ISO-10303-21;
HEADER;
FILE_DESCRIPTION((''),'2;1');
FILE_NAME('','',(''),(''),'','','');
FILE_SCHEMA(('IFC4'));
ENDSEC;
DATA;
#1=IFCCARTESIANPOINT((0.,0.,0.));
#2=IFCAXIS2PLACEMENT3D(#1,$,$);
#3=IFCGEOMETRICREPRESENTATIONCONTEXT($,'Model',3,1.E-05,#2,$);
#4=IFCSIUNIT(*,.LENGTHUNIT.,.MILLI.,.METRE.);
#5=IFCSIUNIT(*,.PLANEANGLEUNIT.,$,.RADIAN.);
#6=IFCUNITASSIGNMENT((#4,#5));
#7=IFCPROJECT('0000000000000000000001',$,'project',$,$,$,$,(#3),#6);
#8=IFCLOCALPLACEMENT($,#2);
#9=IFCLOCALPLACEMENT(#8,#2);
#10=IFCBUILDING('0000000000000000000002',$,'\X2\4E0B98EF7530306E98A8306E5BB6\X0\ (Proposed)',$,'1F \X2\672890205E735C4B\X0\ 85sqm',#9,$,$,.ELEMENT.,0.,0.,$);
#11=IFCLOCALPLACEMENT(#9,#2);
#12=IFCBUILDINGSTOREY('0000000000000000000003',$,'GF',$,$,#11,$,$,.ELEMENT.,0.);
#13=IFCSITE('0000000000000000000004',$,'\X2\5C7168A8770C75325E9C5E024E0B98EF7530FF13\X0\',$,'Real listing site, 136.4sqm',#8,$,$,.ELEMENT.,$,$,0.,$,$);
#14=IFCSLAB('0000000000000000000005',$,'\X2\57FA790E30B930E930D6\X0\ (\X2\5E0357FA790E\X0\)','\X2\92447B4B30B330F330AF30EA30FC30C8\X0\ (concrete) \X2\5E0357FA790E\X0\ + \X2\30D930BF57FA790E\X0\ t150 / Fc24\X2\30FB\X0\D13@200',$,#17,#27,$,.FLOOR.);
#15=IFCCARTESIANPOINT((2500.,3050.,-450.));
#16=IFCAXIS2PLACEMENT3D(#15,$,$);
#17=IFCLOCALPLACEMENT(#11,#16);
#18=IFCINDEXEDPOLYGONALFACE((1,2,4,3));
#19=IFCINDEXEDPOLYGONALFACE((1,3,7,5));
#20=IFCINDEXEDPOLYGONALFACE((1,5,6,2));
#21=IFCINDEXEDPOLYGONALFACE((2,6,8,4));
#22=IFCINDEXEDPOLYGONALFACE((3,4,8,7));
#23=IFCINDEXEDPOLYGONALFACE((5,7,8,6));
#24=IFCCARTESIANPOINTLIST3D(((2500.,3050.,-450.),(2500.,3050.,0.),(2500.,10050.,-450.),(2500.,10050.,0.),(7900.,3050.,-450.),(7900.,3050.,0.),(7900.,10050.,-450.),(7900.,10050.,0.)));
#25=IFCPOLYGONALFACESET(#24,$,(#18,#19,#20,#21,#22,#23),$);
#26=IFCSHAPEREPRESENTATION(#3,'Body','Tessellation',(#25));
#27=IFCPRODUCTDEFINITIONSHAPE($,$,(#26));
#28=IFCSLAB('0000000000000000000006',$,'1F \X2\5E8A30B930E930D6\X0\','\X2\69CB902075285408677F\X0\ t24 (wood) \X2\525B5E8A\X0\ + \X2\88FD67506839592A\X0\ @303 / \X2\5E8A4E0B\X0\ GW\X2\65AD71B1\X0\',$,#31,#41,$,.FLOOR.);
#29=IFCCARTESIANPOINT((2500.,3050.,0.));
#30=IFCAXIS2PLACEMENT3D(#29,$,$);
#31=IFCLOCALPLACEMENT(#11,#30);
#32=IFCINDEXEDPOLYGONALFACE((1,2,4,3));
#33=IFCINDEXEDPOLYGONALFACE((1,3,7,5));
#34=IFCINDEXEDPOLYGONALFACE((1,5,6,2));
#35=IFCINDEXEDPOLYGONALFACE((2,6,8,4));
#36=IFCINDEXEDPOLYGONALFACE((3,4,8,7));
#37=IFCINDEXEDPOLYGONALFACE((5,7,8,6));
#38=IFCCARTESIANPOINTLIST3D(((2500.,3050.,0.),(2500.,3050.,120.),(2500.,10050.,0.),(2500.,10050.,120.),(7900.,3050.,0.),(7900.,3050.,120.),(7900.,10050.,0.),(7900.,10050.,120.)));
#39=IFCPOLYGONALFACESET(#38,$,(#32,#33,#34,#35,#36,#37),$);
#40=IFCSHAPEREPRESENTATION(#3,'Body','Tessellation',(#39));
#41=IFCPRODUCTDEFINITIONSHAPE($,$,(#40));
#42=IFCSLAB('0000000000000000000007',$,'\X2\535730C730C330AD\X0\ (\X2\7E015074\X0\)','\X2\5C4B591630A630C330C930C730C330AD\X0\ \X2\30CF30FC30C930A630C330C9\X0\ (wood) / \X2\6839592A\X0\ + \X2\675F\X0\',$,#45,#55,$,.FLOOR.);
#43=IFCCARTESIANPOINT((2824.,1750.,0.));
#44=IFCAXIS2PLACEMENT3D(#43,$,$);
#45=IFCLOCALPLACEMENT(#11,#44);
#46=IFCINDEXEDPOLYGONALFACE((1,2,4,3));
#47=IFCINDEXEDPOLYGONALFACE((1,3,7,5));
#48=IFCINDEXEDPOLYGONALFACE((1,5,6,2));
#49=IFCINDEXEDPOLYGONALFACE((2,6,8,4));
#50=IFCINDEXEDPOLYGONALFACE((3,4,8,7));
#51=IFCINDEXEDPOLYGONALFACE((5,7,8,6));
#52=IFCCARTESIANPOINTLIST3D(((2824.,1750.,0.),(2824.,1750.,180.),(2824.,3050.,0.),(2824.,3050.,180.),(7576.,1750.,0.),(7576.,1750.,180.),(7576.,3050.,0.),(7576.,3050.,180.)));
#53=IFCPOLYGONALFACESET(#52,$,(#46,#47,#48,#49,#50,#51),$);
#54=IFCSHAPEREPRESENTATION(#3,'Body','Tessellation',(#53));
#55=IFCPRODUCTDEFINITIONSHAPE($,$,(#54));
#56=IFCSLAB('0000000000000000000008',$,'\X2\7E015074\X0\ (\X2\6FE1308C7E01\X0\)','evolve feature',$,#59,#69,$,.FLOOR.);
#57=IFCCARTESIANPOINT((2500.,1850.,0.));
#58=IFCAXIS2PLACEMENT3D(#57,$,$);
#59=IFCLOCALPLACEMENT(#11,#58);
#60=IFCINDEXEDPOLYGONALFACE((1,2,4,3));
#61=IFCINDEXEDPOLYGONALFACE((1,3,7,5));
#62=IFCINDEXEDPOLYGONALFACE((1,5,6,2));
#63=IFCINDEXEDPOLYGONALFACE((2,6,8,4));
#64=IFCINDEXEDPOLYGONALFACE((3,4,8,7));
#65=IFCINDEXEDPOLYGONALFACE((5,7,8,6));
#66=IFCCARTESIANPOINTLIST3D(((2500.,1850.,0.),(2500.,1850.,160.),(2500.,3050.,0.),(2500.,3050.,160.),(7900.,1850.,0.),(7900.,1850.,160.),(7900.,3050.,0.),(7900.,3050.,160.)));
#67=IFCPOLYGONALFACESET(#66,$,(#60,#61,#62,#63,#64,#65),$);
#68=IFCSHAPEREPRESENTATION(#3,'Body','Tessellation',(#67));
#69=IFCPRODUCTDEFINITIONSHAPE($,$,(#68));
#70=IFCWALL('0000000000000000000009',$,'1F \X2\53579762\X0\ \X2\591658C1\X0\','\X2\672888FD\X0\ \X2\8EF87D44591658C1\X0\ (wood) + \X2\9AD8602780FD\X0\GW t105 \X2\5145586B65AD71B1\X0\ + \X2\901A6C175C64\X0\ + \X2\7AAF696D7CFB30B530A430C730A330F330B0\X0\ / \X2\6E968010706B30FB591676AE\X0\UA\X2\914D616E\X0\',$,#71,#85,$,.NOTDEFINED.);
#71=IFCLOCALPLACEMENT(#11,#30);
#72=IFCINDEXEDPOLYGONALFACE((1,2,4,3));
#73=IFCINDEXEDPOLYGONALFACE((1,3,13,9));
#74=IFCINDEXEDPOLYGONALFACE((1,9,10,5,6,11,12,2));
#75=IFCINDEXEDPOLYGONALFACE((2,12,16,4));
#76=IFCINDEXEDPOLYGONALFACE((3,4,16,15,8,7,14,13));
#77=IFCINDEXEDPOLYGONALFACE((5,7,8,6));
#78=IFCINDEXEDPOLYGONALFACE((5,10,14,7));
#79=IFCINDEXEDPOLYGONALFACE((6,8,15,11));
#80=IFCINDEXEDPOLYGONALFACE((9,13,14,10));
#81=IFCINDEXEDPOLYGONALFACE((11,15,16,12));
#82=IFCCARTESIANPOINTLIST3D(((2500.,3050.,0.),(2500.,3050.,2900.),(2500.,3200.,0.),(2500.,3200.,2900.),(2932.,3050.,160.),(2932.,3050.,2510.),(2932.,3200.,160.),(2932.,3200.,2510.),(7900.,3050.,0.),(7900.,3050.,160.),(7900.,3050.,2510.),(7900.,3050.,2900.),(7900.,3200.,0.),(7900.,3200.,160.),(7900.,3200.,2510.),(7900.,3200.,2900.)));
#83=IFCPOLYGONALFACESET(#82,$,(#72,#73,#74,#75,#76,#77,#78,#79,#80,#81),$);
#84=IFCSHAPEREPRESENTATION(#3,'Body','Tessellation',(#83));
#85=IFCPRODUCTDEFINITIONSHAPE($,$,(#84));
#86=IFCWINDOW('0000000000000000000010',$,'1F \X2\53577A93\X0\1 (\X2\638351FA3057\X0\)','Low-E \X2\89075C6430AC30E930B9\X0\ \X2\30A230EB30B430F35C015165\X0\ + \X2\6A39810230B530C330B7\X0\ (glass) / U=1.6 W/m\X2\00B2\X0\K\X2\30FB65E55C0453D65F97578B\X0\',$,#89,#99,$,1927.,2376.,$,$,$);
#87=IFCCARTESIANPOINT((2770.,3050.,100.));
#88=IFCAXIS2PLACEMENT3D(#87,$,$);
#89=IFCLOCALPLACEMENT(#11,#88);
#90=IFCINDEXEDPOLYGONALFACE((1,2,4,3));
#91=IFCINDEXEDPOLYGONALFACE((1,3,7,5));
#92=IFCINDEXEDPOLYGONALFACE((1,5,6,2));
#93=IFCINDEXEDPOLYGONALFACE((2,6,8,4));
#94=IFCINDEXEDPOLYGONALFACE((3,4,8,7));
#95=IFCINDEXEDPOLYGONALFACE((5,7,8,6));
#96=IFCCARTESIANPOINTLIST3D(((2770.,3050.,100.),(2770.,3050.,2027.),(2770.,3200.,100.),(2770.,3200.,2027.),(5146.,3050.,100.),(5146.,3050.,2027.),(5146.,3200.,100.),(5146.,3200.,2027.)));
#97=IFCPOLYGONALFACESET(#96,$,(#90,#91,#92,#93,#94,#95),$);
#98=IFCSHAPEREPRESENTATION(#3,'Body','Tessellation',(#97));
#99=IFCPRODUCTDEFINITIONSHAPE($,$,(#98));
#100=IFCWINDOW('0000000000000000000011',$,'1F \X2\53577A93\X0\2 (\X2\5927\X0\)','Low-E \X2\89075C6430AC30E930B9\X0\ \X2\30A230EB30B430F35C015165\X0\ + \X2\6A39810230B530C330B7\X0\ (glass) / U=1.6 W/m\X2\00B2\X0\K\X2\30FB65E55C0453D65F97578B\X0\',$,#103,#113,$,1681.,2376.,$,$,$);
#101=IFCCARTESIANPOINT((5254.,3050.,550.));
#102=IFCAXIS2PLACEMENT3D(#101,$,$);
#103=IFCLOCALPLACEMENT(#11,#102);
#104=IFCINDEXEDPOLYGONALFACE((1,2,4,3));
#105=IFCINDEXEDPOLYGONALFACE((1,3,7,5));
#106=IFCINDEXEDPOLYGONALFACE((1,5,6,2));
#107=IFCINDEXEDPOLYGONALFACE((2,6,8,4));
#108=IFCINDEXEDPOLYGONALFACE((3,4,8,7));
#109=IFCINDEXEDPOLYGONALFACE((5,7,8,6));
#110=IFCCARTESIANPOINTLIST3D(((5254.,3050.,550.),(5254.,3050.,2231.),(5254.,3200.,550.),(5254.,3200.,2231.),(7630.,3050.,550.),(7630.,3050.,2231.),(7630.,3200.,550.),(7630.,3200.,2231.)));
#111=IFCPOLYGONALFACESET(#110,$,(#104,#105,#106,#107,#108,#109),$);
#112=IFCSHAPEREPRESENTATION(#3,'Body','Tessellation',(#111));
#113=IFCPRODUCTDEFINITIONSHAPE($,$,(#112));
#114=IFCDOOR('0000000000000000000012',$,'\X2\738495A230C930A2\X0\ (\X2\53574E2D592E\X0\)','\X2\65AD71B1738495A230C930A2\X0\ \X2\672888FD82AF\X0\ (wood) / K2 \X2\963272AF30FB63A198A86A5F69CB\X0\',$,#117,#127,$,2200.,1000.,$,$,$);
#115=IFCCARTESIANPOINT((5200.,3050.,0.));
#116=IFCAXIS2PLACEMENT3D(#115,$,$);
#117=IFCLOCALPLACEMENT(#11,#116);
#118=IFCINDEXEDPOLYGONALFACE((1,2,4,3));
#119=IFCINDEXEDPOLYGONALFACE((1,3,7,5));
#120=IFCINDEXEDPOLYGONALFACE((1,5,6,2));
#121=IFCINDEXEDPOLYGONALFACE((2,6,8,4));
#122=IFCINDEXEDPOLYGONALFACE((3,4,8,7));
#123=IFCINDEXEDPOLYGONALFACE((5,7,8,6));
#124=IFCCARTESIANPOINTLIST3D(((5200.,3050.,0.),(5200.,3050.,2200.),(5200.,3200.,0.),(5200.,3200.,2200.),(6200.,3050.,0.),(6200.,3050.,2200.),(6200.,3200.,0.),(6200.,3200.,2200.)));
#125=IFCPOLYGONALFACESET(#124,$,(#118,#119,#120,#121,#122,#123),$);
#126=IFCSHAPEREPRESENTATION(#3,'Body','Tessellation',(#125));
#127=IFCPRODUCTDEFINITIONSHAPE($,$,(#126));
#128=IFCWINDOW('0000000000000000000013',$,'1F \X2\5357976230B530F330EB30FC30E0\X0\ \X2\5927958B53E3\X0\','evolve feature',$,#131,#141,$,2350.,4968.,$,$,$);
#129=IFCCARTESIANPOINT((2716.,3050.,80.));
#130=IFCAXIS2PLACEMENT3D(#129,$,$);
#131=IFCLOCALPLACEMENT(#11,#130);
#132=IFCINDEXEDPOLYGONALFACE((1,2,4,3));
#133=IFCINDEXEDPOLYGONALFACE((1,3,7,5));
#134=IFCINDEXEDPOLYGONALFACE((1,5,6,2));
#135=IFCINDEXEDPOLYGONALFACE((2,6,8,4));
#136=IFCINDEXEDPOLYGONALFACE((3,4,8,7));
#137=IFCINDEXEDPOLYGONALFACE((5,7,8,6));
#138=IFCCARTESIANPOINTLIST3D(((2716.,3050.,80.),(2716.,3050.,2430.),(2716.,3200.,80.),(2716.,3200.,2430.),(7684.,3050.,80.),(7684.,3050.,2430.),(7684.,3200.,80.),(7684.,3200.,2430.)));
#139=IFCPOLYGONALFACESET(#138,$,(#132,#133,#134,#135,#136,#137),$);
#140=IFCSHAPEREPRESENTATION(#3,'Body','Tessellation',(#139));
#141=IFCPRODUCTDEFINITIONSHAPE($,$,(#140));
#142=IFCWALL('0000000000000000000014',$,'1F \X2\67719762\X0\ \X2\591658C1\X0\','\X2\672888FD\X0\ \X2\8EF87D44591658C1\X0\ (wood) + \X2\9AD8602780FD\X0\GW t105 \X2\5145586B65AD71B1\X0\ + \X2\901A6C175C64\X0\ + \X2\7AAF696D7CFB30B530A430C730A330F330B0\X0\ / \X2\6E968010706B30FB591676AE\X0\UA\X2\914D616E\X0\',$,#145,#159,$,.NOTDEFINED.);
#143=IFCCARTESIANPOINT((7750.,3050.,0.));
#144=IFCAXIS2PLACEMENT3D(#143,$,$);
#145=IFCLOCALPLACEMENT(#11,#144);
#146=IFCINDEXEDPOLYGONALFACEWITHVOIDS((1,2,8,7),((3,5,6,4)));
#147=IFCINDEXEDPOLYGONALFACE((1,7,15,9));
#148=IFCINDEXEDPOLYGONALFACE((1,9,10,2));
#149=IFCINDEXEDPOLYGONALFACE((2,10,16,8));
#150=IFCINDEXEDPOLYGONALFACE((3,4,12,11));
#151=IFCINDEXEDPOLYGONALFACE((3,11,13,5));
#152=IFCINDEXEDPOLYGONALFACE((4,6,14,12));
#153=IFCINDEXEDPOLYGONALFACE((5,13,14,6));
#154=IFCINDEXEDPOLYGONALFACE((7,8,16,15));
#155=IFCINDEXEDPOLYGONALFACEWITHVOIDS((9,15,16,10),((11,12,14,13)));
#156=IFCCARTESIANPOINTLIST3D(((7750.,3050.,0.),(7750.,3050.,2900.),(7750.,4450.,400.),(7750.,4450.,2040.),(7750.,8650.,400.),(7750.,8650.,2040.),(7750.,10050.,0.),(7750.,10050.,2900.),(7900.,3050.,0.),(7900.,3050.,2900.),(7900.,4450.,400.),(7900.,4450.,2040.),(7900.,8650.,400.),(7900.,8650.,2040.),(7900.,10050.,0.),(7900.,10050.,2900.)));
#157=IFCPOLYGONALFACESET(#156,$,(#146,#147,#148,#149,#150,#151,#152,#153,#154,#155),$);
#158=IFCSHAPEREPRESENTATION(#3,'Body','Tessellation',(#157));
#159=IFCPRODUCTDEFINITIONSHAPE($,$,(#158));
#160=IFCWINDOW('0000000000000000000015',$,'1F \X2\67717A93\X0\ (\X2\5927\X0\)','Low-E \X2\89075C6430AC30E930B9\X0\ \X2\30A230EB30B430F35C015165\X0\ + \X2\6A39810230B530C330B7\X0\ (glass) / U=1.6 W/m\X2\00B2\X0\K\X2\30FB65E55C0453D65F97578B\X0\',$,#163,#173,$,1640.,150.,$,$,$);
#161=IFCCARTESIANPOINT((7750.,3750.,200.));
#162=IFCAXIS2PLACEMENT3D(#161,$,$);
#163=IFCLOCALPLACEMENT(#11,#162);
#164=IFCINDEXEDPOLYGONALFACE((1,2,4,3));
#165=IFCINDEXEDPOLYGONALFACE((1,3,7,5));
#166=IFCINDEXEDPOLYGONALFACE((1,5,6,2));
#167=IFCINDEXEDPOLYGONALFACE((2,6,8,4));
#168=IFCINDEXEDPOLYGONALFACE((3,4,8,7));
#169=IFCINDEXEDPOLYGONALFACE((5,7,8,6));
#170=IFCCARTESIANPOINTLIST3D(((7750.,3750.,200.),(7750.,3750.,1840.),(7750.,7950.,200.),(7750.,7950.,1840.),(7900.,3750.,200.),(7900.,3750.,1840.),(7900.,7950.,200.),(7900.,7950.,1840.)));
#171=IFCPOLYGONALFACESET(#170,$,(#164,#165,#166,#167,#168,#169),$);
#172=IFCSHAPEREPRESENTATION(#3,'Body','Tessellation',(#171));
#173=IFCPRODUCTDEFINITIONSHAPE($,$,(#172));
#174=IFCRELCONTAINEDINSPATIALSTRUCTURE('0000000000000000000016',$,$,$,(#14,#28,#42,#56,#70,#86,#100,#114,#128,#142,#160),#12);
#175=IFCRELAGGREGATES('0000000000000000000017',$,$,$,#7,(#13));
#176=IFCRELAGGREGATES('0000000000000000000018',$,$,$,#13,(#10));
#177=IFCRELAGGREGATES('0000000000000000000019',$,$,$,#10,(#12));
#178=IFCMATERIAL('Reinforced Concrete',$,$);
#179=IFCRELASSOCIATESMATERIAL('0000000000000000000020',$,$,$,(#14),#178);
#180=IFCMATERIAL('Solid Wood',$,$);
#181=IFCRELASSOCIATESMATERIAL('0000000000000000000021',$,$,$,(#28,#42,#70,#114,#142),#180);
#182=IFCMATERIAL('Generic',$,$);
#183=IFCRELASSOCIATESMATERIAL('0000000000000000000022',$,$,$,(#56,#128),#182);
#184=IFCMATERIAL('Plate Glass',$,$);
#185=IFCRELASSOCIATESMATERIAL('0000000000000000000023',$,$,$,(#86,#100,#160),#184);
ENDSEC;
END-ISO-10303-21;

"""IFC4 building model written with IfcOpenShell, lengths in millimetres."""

from ifc_helpers import new_model, si_unit, frame, frame_2d, origin, place, context, project, spatial, rectangle, extrude, material, element, fill, save


model = new_model("IFC4")

# Units and contexts
model_context = context("Model", 3, precision=1e-05, world=origin())
ifc_project = project(units=[si_unit("LENGTHUNIT", "METRE", prefix="MILLI"), si_unit("PLANEANGLEUNIT", "RADIAN")], contexts=[model_context])

# Site, building, storey
site_placement = place(None, origin())
site = spatial("IfcSite", under=ifc_project, at=site_placement, Name="山梨県甲府市下飯田３", ObjectType="Real listing site, 136.4sqm", CompositionType="ELEMENT", RefElevation=0.0)
building_placement = place(site_placement, origin())
building = spatial("IfcBuilding", under=site, at=building_placement, Name="下飯田の風の家 (Proposed)", ObjectType="1F 木造平屋 85sqm", CompositionType="ELEMENT", ElevationOfRefHeight=0.0, ElevationOfTerrain=0.0)
storey_placement = place(building_placement, origin())
storey = spatial("IfcBuildingStorey", under=building, at=storey_placement, Name="GF", CompositionType="ELEMENT", Elevation=0.0)

# Slabs
ifc_material_1 = material(Name="Reinforced Concrete")
slab_1_placement = place(storey_placement, frame((2500.0, 3050.0, -450.0)))
element("IfcSlab", 1, at=slab_1_placement, inside=storey, material=ifc_material_1, Name="基礎スラブ (布基礎)", Description="鉄筋コンクリート (concrete) 布基礎 + ベタ基礎 t150 / Fc24・D13@200", PredefinedType="FLOOR", context=model_context, shape_type="SweptSolid", body=[
    extrude(rectangle(XDim=5400.0, YDim=7000.0, at=frame_2d((2700.0, 3500.0))), frame((2500.0, 3050.0, -450.0)), (0.0, 0.0, 1.0), 450.0),
])
ifc_material_2 = material(Name="Solid Wood")
slab_2_placement = place(storey_placement, frame((2500.0, 3050.0, 0.0)))
element("IfcSlab", 2, at=slab_2_placement, inside=storey, material=ifc_material_2, Name="1F 床スラブ", Description="構造用合板 t24 (wood) 剛床 + 製材根太 @303 / 床下 GW断熱", PredefinedType="FLOOR", context=model_context, shape_type="SweptSolid", body=[
    extrude(rectangle(XDim=5400.0, YDim=7000.0, at=frame_2d((2700.0, 3500.0))), frame((2500.0, 3050.0, 0.0)), (0.0, 0.0, 1.0), 120.0),
])
slab_3_placement = place(storey_placement, frame((2824.0, 1750.0, 0.0)))
element("IfcSlab", 3, at=slab_3_placement, inside=storey, material=ifc_material_2, Name="南デッキ (縁側)", Description="屋外ウッドデッキ ハードウッド (wood) / 根太 + 束", PredefinedType="FLOOR", context=model_context, shape_type="SweptSolid", body=[
    extrude(rectangle(XDim=4752.0, YDim=1300.0, at=frame_2d((2376.0, 650.0))), frame((2824.0, 1750.0, 0.0)), (0.0, 0.0, 1.0), 180.0),
])
ifc_material_3 = material(Name="Generic")
slab_4_placement = place(storey_placement, frame((2500.0, 1850.0, 0.0)))
element("IfcSlab", 4, at=slab_4_placement, inside=storey, material=ifc_material_3, Name="縁側 (濡れ縁)", Description="evolve feature", PredefinedType="FLOOR", context=model_context, shape_type="SweptSolid", body=[
    extrude(rectangle(XDim=5400.0, YDim=1200.0, at=frame_2d((2700.0, 600.0))), frame((2500.0, 1850.0, 0.0)), (0.0, 0.0, 1.0), 160.0),
])

# Wall, openings, windows, door
wall_1_placement = place(storey_placement, frame((2500.0, 3050.0, 0.0)))
wall_1 = element("IfcWall", 5, at=wall_1_placement, inside=storey, material=ifc_material_2, Name="1F 南面 外壁", Description="木製 軸組外壁 (wood) + 高性能GW t105 充填断熱 + 通気層 + 窯業系サイディング / 準耐火・外皮UA配慮", PredefinedType="NOTDEFINED", context=model_context, shape_type="SweptSolid", body=[
    extrude(rectangle(XDim=5400.0, YDim=150.0, at=frame_2d((2700.0, 75.0))), frame((2500.0, 3050.0, 0.0)), (0.0, 0.0, 1.0), 2900.0),
])
opening_1_placement = place(storey_placement, frame((2770.0, 3050.0, 100.0)))
opening_1 = element("IfcOpeningElement", 6, at=opening_1_placement, cuts=wall_1, PredefinedType="NOTDEFINED", context=model_context, shape_type="SweptSolid", body=[
    extrude(rectangle(XDim=2376.0, YDim=150.0, at=frame_2d((1188.0, 75.0))), frame((2770.0, 3050.0, 100.0)), (0.0, 0.0, 1.0), 1927.0),
])
opening_2_placement = place(storey_placement, frame((5254.0, 3050.0, 550.0)))
opening_2 = element("IfcOpeningElement", 7, at=opening_2_placement, cuts=wall_1, PredefinedType="NOTDEFINED", context=model_context, shape_type="SweptSolid", body=[
    extrude(rectangle(XDim=2376.0, YDim=150.0, at=frame_2d((1188.0, 75.0))), frame((5254.0, 3050.0, 550.0)), (0.0, 0.0, 1.0), 1681.0),
])
opening_3_placement = place(storey_placement, frame((5200.0, 3050.0, 0.0)))
opening_3 = element("IfcOpeningElement", 8, at=opening_3_placement, cuts=wall_1, PredefinedType="NOTDEFINED", context=model_context, shape_type="SweptSolid", body=[
    extrude(rectangle(XDim=1000.0, YDim=150.0, at=frame_2d((500.0, 75.0))), frame((5200.0, 3050.0, 0.0)), (0.0, 0.0, 1.0), 2200.0),
])
opening_4_placement = place(storey_placement, frame((2716.0, 3050.0, 80.0)))
opening_4 = element("IfcOpeningElement", 9, at=opening_4_placement, cuts=wall_1, PredefinedType="NOTDEFINED", context=model_context, shape_type="SweptSolid", body=[
    extrude(rectangle(XDim=4968.0, YDim=150.0, at=frame_2d((2484.0, 75.0))), frame((2716.0, 3050.0, 80.0)), (0.0, 0.0, 1.0), 2350.0),
])
ifc_material_4 = material(Name="Plate Glass")
window_1_placement = place(storey_placement, frame((2770.0, 3050.0, 100.0)))
window_1 = element("IfcWindow", 10, at=window_1_placement, inside=storey, material=ifc_material_4, Name="1F 南窓1 (掃出し)", Description="Low-E 複層ガラス アルゴン封入 + 樹脂サッシ (glass) / U=1.6 W/m²K・日射取得型", OverallHeight=1927.0, OverallWidth=2376.0, context=model_context, shape_type="SweptSolid", body=[
    extrude(rectangle(XDim=2376.0, YDim=150.0, at=frame_2d((1188.0, 75.0))), frame((2770.0, 3050.0, 100.0)), (0.0, 0.0, 1.0), 1927.0),
])
fill(opening_1, window_1)
window_2_placement = place(storey_placement, frame((5254.0, 3050.0, 550.0)))
window_2 = element("IfcWindow", 11, at=window_2_placement, inside=storey, material=ifc_material_4, Name="1F 南窓2 (大)", Description="Low-E 複層ガラス アルゴン封入 + 樹脂サッシ (glass) / U=1.6 W/m²K・日射取得型", OverallHeight=1681.0, OverallWidth=2376.0, context=model_context, shape_type="SweptSolid", body=[
    extrude(rectangle(XDim=2376.0, YDim=150.0, at=frame_2d((1188.0, 75.0))), frame((5254.0, 3050.0, 550.0)), (0.0, 0.0, 1.0), 1681.0),
])
fill(opening_2, window_2)
door_placement = place(storey_placement, frame((5200.0, 3050.0, 0.0)))
door = element("IfcDoor", 12, at=door_placement, inside=storey, material=ifc_material_2, Name="玄関ドア (南中央)", Description="断熱玄関ドア 木製芯 (wood) / K2 防犯・採風機構", OverallHeight=2200.0, OverallWidth=1000.0, context=model_context, shape_type="SweptSolid", body=[
    extrude(rectangle(XDim=1000.0, YDim=150.0, at=frame_2d((500.0, 75.0))), frame((5200.0, 3050.0, 0.0)), (0.0, 0.0, 1.0), 2200.0),
])
fill(opening_3, door)
window_3_placement = place(storey_placement, frame((2716.0, 3050.0, 80.0)))
window_3 = element("IfcWindow", 13, at=window_3_placement, inside=storey, material=ifc_material_3, Name="1F 南面サンルーム 大開口", Description="evolve feature", OverallHeight=2350.0, OverallWidth=4968.0, context=model_context, shape_type="SweptSolid", body=[
    extrude(rectangle(XDim=4968.0, YDim=150.0, at=frame_2d((2484.0, 75.0))), frame((2716.0, 3050.0, 80.0)), (0.0, 0.0, 1.0), 2350.0),
])
fill(opening_4, window_3)

# Wall, opening, window
wall_2_placement = place(storey_placement, frame((7750.0, 3050.0, 0.0)))
wall_2 = element("IfcWall", 14, at=wall_2_placement, inside=storey, material=ifc_material_2, Name="1F 東面 外壁", Description="木製 軸組外壁 (wood) + 高性能GW t105 充填断熱 + 通気層 + 窯業系サイディング / 準耐火・外皮UA配慮", PredefinedType="NOTDEFINED", context=model_context, shape_type="SweptSolid", body=[
    extrude(rectangle(XDim=150.0, YDim=7000.0, at=frame_2d((75.0, 3500.0))), frame((7750.0, 3050.0, 0.0)), (0.0, 0.0, 1.0), 2900.0),
])
opening_5_placement = place(storey_placement, frame((7750.0, 3750.0, 200.0)))
opening_5 = element("IfcOpeningElement", 15, at=opening_5_placement, cuts=wall_2, PredefinedType="NOTDEFINED", context=model_context, shape_type="SweptSolid", body=[
    extrude(rectangle(XDim=150.0, YDim=4200.0, at=frame_2d((75.0, 2100.0))), frame((7750.0, 3750.0, 200.0)), (0.0, 0.0, 1.0), 1640.0),
])
window_4_placement = place(storey_placement, frame((7750.0, 3750.0, 200.0)))
window_4 = element("IfcWindow", 16, at=window_4_placement, inside=storey, material=ifc_material_4, Name="1F 東窓 (大)", Description="Low-E 複層ガラス アルゴン封入 + 樹脂サッシ (glass) / U=1.6 W/m²K・日射取得型", OverallHeight=1640.0, OverallWidth=150.0, context=model_context, shape_type="SweptSolid", body=[
    extrude(rectangle(XDim=150.0, YDim=4200.0, at=frame_2d((75.0, 2100.0))), frame((7750.0, 3750.0, 200.0)), (0.0, 0.0, 1.0), 1640.0),
])
fill(opening_5, window_4)

save(model, "model.ifc")
